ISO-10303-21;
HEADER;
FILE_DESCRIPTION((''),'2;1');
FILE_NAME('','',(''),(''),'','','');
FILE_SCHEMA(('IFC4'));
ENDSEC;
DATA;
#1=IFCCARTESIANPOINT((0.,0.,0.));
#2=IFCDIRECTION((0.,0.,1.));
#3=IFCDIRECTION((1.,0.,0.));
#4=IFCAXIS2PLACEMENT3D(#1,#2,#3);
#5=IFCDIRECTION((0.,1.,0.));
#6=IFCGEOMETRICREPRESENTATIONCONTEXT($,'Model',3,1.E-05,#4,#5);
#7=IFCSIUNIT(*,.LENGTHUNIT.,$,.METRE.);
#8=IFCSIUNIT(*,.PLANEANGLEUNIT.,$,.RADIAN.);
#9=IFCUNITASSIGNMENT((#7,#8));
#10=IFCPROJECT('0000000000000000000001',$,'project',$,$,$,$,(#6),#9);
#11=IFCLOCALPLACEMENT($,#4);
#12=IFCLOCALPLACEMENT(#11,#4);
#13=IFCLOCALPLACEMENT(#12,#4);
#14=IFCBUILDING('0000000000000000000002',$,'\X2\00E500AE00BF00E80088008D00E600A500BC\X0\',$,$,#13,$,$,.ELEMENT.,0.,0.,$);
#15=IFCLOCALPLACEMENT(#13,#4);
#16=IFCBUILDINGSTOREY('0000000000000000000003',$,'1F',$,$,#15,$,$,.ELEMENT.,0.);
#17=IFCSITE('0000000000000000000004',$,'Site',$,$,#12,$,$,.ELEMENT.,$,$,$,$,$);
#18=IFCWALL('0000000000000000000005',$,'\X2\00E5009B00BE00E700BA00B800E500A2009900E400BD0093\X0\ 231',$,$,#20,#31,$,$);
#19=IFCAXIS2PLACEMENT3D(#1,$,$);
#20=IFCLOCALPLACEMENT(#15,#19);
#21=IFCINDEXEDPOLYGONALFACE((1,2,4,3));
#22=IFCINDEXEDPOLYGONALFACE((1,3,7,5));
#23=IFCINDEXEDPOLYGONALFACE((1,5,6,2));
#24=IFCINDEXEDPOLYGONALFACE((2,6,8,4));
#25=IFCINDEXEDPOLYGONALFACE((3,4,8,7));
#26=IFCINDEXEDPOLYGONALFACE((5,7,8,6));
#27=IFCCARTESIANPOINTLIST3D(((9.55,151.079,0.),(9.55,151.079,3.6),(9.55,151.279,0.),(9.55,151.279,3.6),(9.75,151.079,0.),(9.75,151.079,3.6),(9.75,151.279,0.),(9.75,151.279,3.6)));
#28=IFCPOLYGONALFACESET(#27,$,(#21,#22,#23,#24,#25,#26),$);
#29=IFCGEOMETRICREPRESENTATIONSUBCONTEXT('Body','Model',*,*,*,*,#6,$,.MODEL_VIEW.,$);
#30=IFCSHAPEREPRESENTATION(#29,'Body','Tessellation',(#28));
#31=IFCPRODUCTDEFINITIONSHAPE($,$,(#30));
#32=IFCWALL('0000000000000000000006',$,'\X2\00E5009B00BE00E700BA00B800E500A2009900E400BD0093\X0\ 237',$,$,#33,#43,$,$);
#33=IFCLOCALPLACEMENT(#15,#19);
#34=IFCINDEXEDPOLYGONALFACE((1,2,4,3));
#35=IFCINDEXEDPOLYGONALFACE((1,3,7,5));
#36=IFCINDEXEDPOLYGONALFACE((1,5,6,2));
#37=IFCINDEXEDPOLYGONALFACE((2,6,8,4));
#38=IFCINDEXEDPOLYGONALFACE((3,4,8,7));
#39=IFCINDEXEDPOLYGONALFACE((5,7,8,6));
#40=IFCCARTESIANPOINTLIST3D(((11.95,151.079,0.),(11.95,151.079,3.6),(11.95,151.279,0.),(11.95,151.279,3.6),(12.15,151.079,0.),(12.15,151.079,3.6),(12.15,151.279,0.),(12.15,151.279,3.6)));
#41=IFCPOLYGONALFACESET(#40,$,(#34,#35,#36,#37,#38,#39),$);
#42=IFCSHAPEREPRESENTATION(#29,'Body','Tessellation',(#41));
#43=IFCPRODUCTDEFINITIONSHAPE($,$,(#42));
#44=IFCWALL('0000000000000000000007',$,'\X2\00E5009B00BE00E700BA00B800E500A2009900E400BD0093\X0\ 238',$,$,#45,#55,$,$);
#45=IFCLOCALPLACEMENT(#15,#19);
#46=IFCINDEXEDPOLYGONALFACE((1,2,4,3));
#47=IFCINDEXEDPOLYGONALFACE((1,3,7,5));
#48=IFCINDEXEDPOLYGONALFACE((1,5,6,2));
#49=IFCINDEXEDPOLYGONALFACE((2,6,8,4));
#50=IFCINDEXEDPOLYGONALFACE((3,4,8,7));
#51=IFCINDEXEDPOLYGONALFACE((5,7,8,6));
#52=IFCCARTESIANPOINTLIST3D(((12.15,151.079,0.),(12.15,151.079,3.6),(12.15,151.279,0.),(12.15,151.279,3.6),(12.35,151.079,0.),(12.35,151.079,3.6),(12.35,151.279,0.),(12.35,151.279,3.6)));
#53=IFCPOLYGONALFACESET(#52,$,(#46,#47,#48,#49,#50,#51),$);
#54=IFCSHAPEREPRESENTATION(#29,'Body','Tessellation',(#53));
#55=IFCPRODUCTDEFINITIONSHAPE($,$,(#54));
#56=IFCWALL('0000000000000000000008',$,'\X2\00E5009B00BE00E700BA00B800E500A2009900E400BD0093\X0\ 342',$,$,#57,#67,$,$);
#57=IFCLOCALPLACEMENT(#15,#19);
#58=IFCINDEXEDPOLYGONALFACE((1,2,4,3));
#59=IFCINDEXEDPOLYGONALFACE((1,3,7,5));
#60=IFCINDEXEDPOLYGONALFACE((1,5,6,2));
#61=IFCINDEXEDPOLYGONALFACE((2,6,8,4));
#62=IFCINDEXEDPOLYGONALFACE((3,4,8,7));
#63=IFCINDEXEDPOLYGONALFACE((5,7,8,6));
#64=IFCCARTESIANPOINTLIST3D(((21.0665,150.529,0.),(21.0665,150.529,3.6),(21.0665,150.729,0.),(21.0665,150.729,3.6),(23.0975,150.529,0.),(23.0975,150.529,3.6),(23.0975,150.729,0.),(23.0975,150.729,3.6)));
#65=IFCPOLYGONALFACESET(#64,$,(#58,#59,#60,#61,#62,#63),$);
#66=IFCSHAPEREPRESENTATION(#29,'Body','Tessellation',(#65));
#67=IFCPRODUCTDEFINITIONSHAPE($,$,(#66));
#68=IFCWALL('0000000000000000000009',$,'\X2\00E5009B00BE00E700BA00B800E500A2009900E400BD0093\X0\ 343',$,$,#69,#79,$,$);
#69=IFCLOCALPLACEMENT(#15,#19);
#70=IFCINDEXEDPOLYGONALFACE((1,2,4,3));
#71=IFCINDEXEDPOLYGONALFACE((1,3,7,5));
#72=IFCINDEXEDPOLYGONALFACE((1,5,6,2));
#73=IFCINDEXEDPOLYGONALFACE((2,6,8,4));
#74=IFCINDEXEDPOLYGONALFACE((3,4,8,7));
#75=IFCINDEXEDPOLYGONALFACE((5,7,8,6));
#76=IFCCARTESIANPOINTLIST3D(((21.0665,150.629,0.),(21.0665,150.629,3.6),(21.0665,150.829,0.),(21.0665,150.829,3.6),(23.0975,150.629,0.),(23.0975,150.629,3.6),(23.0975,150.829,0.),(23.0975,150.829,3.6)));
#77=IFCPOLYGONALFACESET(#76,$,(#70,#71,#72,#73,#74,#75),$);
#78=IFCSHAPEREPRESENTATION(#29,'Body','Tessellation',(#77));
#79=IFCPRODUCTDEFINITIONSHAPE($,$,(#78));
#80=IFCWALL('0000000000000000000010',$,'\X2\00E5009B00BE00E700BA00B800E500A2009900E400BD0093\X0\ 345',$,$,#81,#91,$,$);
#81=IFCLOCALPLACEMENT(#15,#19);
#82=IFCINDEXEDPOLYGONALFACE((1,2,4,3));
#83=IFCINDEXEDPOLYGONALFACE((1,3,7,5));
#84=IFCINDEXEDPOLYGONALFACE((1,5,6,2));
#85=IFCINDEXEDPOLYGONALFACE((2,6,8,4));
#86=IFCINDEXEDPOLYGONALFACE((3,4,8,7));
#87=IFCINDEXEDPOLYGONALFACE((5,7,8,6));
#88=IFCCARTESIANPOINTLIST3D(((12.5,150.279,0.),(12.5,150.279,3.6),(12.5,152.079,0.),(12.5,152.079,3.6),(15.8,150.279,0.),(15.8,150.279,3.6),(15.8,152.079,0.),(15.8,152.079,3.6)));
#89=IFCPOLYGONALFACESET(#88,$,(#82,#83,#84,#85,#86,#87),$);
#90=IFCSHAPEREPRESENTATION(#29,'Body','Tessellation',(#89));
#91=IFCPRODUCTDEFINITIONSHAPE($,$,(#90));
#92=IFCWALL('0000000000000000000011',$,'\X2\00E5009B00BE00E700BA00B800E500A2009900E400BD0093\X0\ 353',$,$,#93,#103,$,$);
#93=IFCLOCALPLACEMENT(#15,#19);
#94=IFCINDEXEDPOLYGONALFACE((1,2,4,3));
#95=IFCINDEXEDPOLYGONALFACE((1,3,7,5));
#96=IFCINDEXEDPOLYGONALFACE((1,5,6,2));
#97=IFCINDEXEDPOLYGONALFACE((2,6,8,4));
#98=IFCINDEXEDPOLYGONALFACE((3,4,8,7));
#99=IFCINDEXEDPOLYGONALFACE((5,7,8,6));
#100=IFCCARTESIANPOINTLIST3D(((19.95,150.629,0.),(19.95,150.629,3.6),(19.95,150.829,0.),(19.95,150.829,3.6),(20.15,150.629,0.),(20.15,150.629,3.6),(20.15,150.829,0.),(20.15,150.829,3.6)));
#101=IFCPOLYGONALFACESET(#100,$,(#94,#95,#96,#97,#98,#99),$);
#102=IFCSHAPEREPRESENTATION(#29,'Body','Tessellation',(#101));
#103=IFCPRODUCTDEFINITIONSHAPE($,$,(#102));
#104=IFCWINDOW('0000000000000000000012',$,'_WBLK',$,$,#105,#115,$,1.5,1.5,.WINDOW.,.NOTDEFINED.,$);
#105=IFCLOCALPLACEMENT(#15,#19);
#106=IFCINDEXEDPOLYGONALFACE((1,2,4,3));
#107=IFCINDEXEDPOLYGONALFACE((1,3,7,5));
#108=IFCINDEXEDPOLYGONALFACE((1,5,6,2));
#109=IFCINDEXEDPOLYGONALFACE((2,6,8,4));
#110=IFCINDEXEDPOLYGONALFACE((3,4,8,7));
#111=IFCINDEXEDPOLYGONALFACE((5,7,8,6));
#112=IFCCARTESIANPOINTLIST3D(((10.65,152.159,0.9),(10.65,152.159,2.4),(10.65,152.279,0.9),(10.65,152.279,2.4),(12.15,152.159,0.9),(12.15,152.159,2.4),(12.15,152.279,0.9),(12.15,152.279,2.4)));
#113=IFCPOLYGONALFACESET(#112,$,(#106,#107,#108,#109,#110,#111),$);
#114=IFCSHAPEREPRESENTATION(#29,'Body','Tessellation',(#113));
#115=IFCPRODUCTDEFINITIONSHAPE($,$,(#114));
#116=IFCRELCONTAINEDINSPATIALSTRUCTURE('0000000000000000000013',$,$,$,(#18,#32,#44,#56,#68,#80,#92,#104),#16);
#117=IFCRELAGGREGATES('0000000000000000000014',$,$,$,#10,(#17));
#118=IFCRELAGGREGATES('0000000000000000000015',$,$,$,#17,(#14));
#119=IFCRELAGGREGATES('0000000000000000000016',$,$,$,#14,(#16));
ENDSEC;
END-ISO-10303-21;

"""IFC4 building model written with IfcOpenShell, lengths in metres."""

from ifc_helpers import new_model, si_unit, direction, frame, frame_2d, origin_with_axes, place, context, subcontext, project, spatial, rectangle, extrude, element, save


model = new_model("IFC4")

# Units and contexts
model_context = context("Model", 3, precision=1e-05, world=origin_with_axes(), true_north=direction((0.0, 1.0, 0.0)))
body_context = subcontext(model_context, "Body", "Model", "MODEL_VIEW")
ifc_project = project(units=[si_unit("LENGTHUNIT", "METRE"), si_unit("PLANEANGLEUNIT", "RADIAN")], contexts=[model_context])

# Site, building, storey
placement = place(None, origin_with_axes())
site_placement = place(placement, origin_with_axes())
site = spatial("IfcSite", under=ifc_project, at=site_placement, Name="Site", CompositionType="ELEMENT")
building_placement = place(site_placement, origin_with_axes())
building = spatial("IfcBuilding", under=site, at=building_placement, Name="å®¿è\u0088\u008dæ¥¼", CompositionType="ELEMENT", ElevationOfRefHeight=0.0, ElevationOfTerrain=0.0)
storey_placement = place(building_placement, origin_with_axes())
storey = spatial("IfcBuildingStorey", under=building, at=storey_placement, Name="1F", CompositionType="ELEMENT", Elevation=0.0)

# Walls
for number, where, z_axis, x_axis, name in (
    (1, (9.65, 151.179, 0.0), (0.0, 0.0, 1.0), (1.0, 0.0, 0.0), "å\u009b¾çº¸å¢\u0099ä½\u0093 231"),
    (2, (12.05, 151.179, 0.0), (0.0, 0.0, 1.0), (1.0, 0.0, 0.0), "å\u009b¾çº¸å¢\u0099ä½\u0093 237"),
    (3, (12.25, 151.179, 0.0), (0.0, 0.0, 1.0), (-1.0, 0.0, 0.0), "å\u009b¾çº¸å¢\u0099ä½\u0093 238"),
):
    element("IfcWall", number, at=place(storey_placement, frame(where, z_axis=z_axis, x_axis=x_axis)), inside=storey, Name=name, context=body_context, shape_type="SweptSolid", body=[
        extrude(rectangle(XDim=0.2, YDim=0.2, at=frame_2d((0.0, 0.0), x_axis=(1.0, 0.0, 0.0))), frame((0.0, 0.0, 0.0), z_axis=(0.0, 0.0, 1.0)), (0.0, 0.0, 1.0), 3.6),
    ])
for number, where, z_axis, x_axis, name in (
    (4, (22.082, 150.629, 0.0), (0.0, 0.0, 1.0), (-1.0, 0.0, 0.0), "å\u009b¾çº¸å¢\u0099ä½\u0093 342"),
    (5, (22.082, 150.729, 0.0), (0.0, 0.0, 1.0), (-1.0, 0.0, 0.0), "å\u009b¾çº¸å¢\u0099ä½\u0093 343"),
):
    element("IfcWall", number, at=place(storey_placement, frame(where, z_axis=z_axis, x_axis=x_axis)), inside=storey, Name=name, context=body_context, shape_type="SweptSolid", body=[
        extrude(rectangle(XDim=2.031, YDim=0.2, at=frame_2d((0.0, 0.0), x_axis=(1.0, 0.0, 0.0))), frame((0.0, 0.0, 0.0), z_axis=(0.0, 0.0, 1.0)), (0.0, 0.0, 1.0), 3.6),
    ])
wall_1_placement = place(storey_placement, frame((14.15, 151.179, 0.0), z_axis=(0.0, 0.0, 1.0), x_axis=(1.0, 0.0, 0.0)))
element("IfcWall", 6, at=wall_1_placement, inside=storey, Name="å\u009b¾çº¸å¢\u0099ä½\u0093 345", context=body_context, shape_type="SweptSolid", body=[
    extrude(rectangle(XDim=3.3, YDim=1.8, at=frame_2d((0.0, 0.0), x_axis=(1.0, 0.0, 0.0))), frame((0.0, 0.0, 0.0), z_axis=(0.0, 0.0, 1.0)), (0.0, 0.0, 1.0), 3.6),
])
wall_2_placement = place(storey_placement, frame((20.05, 150.729, 0.0), z_axis=(0.0, 0.0, 1.0), x_axis=(-1.0, 0.0, 0.0)))
element("IfcWall", 7, at=wall_2_placement, inside=storey, Name="å\u009b¾çº¸å¢\u0099ä½\u0093 353", context=body_context, shape_type="SweptSolid", body=[
    extrude(rectangle(XDim=0.2, YDim=0.2, at=frame_2d((0.0, 0.0), x_axis=(1.0, 0.0, 0.0))), frame((0.0, 0.0, 0.0), z_axis=(0.0, 0.0, 1.0)), (0.0, 0.0, 1.0), 3.6),
])

# Window
window_placement = place(storey_placement, frame((11.4, 152.219, 0.9), z_axis=(0.0, 0.0, 1.0), x_axis=(1.0, 0.0, 0.0)))
element("IfcWindow", 8, at=window_placement, inside=storey, Name="_WBLK", OverallHeight=1.5, OverallWidth=1.5, PartitioningType="NOTDEFINED", PredefinedType="WINDOW", context=body_context, shape_type="SweptSolid", body=[
    extrude(rectangle(XDim=1.5, YDim=0.12, at=frame_2d((0.0, 0.0), x_axis=(1.0, 0.0, 0.0))), frame((0.0, 0.0, 0.0), z_axis=(0.0, 0.0, 1.0)), (0.0, 0.0, 1.0), 1.5),
])

save(model, "model.ifc")
